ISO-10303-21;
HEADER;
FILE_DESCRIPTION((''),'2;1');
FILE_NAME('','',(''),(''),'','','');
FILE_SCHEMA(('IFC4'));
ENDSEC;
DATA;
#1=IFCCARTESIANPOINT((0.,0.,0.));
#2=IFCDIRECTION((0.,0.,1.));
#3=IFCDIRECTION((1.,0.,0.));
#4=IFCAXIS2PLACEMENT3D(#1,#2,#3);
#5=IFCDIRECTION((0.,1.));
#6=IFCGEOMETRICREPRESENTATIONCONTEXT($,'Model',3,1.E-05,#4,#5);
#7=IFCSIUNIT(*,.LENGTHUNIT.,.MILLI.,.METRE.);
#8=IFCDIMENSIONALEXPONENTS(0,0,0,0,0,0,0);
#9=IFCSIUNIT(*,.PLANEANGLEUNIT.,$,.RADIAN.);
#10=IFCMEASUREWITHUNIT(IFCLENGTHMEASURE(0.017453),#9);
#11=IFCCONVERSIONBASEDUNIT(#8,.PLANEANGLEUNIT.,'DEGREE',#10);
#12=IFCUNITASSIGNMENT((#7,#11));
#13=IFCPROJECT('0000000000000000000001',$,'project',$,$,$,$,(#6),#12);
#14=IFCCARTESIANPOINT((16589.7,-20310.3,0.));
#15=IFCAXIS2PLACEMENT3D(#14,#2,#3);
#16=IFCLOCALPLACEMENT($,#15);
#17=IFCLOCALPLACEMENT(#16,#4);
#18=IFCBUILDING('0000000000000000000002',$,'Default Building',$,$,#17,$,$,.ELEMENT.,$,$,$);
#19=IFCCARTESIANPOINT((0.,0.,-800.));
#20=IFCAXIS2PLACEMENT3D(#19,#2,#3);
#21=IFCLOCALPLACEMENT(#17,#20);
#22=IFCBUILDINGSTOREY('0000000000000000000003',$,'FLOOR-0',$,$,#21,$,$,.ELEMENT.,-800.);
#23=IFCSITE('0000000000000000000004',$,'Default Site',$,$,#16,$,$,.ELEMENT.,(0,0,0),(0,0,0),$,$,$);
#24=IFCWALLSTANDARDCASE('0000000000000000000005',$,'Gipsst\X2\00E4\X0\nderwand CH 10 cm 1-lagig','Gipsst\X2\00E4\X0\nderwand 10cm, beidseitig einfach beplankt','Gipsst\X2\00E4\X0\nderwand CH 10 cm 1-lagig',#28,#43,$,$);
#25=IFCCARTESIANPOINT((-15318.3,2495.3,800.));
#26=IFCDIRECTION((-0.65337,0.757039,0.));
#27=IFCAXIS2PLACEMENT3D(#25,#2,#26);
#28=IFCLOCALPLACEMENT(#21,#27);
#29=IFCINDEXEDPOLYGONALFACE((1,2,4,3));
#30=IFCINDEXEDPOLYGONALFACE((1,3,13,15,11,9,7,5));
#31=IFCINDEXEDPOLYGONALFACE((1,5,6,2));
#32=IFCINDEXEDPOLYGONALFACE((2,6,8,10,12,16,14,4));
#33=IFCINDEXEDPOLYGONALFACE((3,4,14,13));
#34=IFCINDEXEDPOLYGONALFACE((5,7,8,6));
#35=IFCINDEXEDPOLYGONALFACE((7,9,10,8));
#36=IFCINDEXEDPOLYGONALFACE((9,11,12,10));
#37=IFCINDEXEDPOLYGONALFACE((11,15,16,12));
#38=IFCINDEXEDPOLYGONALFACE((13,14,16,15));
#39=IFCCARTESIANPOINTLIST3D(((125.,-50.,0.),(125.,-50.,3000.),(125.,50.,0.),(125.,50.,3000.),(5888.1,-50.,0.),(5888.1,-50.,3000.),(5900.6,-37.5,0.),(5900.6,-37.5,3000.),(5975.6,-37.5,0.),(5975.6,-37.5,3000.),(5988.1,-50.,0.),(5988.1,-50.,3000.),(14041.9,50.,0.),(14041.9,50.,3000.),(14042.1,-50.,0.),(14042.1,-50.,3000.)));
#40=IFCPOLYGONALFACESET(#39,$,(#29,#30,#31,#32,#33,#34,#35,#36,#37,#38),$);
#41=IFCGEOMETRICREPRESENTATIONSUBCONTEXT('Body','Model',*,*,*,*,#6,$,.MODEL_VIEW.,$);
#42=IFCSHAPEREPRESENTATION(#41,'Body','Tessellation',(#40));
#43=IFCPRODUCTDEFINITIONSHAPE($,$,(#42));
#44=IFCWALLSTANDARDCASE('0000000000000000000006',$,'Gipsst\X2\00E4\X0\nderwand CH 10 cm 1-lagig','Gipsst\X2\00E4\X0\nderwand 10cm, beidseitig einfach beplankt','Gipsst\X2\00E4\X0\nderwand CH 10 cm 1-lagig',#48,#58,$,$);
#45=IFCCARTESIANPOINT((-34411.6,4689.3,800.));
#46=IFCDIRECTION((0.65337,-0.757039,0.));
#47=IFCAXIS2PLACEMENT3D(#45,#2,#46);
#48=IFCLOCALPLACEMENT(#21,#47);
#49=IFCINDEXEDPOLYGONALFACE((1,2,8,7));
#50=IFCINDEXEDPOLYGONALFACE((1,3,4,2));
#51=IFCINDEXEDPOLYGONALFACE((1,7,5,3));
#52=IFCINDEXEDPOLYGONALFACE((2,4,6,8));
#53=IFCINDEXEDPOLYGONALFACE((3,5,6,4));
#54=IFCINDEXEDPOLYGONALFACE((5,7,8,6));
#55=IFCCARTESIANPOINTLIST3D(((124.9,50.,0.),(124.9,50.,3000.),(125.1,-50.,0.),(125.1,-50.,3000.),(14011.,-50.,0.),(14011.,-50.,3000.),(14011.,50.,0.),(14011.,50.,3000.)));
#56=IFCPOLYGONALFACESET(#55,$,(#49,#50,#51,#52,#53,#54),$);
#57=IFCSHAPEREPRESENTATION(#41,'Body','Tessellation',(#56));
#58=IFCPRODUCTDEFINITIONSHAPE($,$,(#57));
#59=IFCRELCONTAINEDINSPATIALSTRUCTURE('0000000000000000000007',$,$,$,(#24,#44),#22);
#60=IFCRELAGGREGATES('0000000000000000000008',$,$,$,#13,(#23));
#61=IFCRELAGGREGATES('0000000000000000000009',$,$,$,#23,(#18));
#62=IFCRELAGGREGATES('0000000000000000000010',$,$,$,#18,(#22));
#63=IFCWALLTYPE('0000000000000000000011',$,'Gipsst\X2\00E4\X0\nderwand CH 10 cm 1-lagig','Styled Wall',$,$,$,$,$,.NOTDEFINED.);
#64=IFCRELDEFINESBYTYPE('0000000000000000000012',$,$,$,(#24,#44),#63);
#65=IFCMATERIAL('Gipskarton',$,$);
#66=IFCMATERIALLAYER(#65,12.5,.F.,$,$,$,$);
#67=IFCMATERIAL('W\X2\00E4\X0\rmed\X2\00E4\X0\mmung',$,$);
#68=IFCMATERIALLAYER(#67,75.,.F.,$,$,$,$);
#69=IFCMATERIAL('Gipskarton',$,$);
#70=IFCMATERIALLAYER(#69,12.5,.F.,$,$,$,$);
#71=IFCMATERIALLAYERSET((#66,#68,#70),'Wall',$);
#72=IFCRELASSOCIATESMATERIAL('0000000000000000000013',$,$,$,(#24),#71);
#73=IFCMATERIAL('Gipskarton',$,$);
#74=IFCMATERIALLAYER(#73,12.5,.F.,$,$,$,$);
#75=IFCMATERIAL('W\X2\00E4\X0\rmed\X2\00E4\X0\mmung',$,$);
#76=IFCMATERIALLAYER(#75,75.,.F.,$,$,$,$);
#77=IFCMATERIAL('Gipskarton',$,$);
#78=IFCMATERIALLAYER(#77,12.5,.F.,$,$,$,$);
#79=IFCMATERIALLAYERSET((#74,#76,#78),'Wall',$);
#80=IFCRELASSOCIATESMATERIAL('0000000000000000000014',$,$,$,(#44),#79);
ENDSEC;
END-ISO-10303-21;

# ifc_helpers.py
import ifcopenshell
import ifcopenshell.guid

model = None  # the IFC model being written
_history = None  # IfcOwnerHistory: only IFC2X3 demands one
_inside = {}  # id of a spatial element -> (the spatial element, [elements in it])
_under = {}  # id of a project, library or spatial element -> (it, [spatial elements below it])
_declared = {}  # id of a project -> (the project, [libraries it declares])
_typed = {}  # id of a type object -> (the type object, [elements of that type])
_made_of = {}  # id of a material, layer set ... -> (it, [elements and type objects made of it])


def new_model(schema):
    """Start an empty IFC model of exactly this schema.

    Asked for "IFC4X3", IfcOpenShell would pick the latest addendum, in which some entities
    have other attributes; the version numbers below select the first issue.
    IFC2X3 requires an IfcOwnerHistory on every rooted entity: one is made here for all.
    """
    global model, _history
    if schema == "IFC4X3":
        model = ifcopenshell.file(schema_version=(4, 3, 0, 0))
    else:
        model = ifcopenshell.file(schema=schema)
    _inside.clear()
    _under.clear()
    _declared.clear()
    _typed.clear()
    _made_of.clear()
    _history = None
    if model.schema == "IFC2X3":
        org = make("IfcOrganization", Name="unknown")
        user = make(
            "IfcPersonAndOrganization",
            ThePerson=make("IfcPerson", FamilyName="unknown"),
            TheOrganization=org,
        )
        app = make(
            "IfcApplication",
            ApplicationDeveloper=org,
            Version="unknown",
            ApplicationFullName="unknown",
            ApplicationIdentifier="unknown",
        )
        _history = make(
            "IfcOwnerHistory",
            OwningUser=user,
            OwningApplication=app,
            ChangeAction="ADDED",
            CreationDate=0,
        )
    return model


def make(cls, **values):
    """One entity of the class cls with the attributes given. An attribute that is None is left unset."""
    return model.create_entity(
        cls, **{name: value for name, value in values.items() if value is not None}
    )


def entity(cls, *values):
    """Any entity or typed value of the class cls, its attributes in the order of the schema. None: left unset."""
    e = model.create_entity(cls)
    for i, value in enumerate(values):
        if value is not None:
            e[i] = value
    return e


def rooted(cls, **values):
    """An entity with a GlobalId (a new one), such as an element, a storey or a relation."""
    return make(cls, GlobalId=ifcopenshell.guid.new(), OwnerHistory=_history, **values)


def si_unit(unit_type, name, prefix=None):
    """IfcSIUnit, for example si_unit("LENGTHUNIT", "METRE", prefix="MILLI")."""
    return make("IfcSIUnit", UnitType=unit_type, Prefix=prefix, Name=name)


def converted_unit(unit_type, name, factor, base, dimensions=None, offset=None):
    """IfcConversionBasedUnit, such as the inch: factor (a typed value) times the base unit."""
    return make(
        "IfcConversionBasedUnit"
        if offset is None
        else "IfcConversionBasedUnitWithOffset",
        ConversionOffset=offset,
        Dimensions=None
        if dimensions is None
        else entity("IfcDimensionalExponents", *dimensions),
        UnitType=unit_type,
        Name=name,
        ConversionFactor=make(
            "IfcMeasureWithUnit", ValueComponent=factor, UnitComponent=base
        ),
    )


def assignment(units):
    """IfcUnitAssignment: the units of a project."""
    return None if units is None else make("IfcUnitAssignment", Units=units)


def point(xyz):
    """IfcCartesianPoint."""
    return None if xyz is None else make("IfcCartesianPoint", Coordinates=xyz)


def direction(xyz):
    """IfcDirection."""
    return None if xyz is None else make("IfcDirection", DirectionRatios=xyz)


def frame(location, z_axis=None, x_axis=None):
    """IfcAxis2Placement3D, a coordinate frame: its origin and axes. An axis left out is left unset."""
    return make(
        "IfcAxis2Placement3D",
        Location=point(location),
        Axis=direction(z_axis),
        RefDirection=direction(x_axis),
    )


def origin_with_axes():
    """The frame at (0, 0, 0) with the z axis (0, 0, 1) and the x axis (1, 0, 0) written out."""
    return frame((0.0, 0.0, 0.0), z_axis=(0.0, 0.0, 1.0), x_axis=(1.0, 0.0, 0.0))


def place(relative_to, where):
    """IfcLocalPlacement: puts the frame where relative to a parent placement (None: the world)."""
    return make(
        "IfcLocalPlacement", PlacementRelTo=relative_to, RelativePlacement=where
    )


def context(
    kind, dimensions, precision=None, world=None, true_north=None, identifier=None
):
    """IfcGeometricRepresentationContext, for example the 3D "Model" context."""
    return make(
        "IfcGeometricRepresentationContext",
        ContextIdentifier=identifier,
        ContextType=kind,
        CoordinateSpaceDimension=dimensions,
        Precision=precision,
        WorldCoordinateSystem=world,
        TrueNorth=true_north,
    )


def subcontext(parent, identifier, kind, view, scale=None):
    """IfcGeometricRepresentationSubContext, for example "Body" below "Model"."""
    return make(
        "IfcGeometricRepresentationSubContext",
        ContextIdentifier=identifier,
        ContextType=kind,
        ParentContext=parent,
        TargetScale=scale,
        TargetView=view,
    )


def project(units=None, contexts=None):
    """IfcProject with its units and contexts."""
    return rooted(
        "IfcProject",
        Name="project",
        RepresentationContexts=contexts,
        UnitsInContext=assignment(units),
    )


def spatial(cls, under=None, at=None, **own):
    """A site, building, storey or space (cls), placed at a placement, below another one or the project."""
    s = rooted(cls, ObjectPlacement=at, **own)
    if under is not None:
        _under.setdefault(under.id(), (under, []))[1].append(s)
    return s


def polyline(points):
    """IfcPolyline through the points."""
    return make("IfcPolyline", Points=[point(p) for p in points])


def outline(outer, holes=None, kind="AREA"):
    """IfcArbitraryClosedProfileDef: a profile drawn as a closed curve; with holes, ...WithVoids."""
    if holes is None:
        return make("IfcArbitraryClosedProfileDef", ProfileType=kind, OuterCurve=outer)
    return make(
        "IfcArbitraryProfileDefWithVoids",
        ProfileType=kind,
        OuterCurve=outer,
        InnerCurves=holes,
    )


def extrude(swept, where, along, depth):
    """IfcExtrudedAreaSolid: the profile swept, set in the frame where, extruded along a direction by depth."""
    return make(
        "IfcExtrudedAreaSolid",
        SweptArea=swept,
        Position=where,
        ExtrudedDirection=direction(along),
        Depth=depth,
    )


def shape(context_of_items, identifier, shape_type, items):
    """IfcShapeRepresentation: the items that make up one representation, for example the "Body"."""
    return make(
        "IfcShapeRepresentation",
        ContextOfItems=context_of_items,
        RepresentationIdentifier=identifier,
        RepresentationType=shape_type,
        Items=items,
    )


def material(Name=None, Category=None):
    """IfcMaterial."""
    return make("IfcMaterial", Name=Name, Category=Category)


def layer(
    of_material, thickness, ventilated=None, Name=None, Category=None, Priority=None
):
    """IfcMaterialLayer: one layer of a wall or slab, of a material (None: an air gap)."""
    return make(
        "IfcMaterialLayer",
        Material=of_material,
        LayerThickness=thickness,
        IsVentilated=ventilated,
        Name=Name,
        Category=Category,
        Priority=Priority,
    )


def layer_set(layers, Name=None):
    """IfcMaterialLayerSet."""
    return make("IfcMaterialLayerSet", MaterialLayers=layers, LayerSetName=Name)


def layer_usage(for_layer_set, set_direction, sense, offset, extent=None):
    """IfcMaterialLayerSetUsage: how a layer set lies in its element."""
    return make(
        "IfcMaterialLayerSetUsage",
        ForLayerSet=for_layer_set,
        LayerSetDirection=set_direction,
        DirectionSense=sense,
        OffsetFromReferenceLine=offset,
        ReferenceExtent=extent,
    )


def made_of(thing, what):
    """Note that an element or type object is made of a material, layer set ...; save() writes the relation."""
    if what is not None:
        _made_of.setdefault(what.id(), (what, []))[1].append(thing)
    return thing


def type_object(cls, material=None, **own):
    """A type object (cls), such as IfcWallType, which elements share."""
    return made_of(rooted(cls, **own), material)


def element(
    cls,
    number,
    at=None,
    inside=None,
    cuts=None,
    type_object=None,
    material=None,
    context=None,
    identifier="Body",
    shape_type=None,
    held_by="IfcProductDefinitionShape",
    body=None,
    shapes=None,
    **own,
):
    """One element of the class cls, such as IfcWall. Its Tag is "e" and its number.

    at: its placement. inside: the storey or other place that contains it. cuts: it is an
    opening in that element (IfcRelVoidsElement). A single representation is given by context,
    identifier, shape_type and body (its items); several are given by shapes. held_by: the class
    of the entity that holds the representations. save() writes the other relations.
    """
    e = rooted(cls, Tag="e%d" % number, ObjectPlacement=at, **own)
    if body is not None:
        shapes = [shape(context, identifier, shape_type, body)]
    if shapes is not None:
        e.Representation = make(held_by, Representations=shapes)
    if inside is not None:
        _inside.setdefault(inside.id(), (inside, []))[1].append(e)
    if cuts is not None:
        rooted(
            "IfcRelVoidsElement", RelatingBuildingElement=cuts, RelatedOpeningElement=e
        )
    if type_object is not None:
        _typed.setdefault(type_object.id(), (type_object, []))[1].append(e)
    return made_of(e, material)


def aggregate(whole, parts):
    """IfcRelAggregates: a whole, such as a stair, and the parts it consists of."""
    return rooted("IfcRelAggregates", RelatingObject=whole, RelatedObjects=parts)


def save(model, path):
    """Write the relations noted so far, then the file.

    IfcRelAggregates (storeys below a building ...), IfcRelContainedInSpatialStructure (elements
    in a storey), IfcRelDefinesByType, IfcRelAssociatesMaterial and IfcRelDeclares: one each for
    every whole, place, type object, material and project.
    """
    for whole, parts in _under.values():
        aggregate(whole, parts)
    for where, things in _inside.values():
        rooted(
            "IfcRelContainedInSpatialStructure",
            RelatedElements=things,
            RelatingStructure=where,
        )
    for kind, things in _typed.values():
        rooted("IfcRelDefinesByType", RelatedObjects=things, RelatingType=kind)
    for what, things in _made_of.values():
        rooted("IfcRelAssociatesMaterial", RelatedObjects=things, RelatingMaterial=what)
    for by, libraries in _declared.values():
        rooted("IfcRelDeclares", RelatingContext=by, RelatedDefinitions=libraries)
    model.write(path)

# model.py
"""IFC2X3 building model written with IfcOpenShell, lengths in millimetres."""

from ifc_helpers import new_model, entity, si_unit, converted_unit, direction, frame, origin_with_axes, place, context, subcontext, project, spatial, polyline, outline, extrude, material, layer, layer_set, layer_usage, type_object, element, save


model = new_model("IFC2X3")

# Units and contexts
model_context = context("Model", 3, precision=1e-05, world=origin_with_axes(), true_north=direction((0.0, 1.0)))
body_context = subcontext(model_context, "Body", "Model", "MODEL_VIEW")
ifc_project = project(units=[si_unit("LENGTHUNIT", "METRE", prefix="MILLI"), converted_unit("PLANEANGLEUNIT", "DEGREE", entity("IfcLengthMeasure", 0.017453), si_unit("PLANEANGLEUNIT", "RADIAN"), dimensions=[0, 0, 0, 0, 0, 0, 0])], contexts=[model_context])

# Site, building, storey
site_placement = place(None, frame((16589.7, -20310.3, 0.0), z_axis=(0.0, 0.0, 1.0), x_axis=(1.0, 0.0, 0.0)))
site = spatial("IfcSite", under=ifc_project, at=site_placement, Name="Default Site", CompositionType="ELEMENT", RefLatitude=(0, 0, 0), RefLongitude=(0, 0, 0))
building_placement = place(site_placement, origin_with_axes())
building = spatial("IfcBuilding", under=site, at=building_placement, Name="Default Building", CompositionType="ELEMENT")
storey_placement = place(building_placement, frame((0.0, 0.0, -800.0), z_axis=(0.0, 0.0, 1.0), x_axis=(1.0, 0.0, 0.0)))
storey = spatial("IfcBuildingStorey", under=building, at=storey_placement, Name="FLOOR-0", CompositionType="ELEMENT", Elevation=-800.0)

# Walls
ifc_material_1 = material(Name="Gipskarton")
ifc_layer_1 = layer(ifc_material_1, 12.5, ventilated=False)
ifc_material_2 = material(Name="Wärmedämmung")
ifc_layer_2 = layer(ifc_material_2, 75.0, ventilated=False)
ifc_material_3 = material(Name="Gipskarton")
ifc_layer_3 = layer(ifc_material_3, 12.5, ventilated=False)
ifc_layer_set_1 = layer_set([ifc_layer_1, ifc_layer_2, ifc_layer_3], Name="Wall")
ifc_layer_usage_1 = layer_usage(ifc_layer_set_1, "AXIS2", "NEGATIVE", 50.0)
wall_type_1 = type_object("IfcWallType", Name="Gipsständerwand CH 10 cm 1-lagig", Description="Styled Wall", PredefinedType="NOTDEFINED")
wall_1_placement = place(storey_placement, frame((-15318.3, 2495.3, 800.0), z_axis=(0.0, 0.0, 1.0), x_axis=(-0.65337, 0.757039, 0.0)))
element("IfcWallStandardCase", 1, at=wall_1_placement, inside=storey, type_object=wall_type_1, material=ifc_layer_usage_1, Name="Gipsständerwand CH 10 cm 1-lagig", Description="Gipsständerwand 10cm, beidseitig einfach beplankt", ObjectType="Gipsständerwand CH 10 cm 1-lagig", context=body_context, shape_type="SweptSolid", body=[
    extrude(outline(polyline([(14042.1, -50.0), (14041.9, 50.0), (125.0, 50.0), (125.0, -50.0), (5888.1, -50.0), (5900.6, -37.5), (5975.6, -37.5), (5988.1, -50.0), (14042.1, -50.0)])), origin_with_axes(), (0.0, 0.0, 1.0), 3000.0),
])
ifc_material_4 = material(Name="Gipskarton")
ifc_layer_4 = layer(ifc_material_4, 12.5, ventilated=False)
ifc_material_5 = material(Name="Wärmedämmung")
ifc_layer_5 = layer(ifc_material_5, 75.0, ventilated=False)
ifc_material_6 = material(Name="Gipskarton")
ifc_layer_6 = layer(ifc_material_6, 12.5, ventilated=False)
ifc_layer_set_2 = layer_set([ifc_layer_4, ifc_layer_5, ifc_layer_6], Name="Wall")
ifc_layer_usage_2 = layer_usage(ifc_layer_set_2, "AXIS2", "NEGATIVE", 50.0)
wall_2_placement = place(storey_placement, frame((-34411.6, 4689.3, 800.0), z_axis=(0.0, 0.0, 1.0), x_axis=(0.65337, -0.757039, 0.0)))
element("IfcWallStandardCase", 2, at=wall_2_placement, inside=storey, type_object=wall_type_1, material=ifc_layer_usage_2, Name="Gipsständerwand CH 10 cm 1-lagig", Description="Gipsständerwand 10cm, beidseitig einfach beplankt", ObjectType="Gipsständerwand CH 10 cm 1-lagig", context=body_context, shape_type="SweptSolid", body=[
    extrude(outline(polyline([(14011.0, -50.0), (14011.0, 50.0), (124.9, 50.0), (125.1, -50.0), (14011.0, -50.0)])), origin_with_axes(), (0.0, 0.0, 1.0), 3000.0),
])

save(model, "model.ifc")
